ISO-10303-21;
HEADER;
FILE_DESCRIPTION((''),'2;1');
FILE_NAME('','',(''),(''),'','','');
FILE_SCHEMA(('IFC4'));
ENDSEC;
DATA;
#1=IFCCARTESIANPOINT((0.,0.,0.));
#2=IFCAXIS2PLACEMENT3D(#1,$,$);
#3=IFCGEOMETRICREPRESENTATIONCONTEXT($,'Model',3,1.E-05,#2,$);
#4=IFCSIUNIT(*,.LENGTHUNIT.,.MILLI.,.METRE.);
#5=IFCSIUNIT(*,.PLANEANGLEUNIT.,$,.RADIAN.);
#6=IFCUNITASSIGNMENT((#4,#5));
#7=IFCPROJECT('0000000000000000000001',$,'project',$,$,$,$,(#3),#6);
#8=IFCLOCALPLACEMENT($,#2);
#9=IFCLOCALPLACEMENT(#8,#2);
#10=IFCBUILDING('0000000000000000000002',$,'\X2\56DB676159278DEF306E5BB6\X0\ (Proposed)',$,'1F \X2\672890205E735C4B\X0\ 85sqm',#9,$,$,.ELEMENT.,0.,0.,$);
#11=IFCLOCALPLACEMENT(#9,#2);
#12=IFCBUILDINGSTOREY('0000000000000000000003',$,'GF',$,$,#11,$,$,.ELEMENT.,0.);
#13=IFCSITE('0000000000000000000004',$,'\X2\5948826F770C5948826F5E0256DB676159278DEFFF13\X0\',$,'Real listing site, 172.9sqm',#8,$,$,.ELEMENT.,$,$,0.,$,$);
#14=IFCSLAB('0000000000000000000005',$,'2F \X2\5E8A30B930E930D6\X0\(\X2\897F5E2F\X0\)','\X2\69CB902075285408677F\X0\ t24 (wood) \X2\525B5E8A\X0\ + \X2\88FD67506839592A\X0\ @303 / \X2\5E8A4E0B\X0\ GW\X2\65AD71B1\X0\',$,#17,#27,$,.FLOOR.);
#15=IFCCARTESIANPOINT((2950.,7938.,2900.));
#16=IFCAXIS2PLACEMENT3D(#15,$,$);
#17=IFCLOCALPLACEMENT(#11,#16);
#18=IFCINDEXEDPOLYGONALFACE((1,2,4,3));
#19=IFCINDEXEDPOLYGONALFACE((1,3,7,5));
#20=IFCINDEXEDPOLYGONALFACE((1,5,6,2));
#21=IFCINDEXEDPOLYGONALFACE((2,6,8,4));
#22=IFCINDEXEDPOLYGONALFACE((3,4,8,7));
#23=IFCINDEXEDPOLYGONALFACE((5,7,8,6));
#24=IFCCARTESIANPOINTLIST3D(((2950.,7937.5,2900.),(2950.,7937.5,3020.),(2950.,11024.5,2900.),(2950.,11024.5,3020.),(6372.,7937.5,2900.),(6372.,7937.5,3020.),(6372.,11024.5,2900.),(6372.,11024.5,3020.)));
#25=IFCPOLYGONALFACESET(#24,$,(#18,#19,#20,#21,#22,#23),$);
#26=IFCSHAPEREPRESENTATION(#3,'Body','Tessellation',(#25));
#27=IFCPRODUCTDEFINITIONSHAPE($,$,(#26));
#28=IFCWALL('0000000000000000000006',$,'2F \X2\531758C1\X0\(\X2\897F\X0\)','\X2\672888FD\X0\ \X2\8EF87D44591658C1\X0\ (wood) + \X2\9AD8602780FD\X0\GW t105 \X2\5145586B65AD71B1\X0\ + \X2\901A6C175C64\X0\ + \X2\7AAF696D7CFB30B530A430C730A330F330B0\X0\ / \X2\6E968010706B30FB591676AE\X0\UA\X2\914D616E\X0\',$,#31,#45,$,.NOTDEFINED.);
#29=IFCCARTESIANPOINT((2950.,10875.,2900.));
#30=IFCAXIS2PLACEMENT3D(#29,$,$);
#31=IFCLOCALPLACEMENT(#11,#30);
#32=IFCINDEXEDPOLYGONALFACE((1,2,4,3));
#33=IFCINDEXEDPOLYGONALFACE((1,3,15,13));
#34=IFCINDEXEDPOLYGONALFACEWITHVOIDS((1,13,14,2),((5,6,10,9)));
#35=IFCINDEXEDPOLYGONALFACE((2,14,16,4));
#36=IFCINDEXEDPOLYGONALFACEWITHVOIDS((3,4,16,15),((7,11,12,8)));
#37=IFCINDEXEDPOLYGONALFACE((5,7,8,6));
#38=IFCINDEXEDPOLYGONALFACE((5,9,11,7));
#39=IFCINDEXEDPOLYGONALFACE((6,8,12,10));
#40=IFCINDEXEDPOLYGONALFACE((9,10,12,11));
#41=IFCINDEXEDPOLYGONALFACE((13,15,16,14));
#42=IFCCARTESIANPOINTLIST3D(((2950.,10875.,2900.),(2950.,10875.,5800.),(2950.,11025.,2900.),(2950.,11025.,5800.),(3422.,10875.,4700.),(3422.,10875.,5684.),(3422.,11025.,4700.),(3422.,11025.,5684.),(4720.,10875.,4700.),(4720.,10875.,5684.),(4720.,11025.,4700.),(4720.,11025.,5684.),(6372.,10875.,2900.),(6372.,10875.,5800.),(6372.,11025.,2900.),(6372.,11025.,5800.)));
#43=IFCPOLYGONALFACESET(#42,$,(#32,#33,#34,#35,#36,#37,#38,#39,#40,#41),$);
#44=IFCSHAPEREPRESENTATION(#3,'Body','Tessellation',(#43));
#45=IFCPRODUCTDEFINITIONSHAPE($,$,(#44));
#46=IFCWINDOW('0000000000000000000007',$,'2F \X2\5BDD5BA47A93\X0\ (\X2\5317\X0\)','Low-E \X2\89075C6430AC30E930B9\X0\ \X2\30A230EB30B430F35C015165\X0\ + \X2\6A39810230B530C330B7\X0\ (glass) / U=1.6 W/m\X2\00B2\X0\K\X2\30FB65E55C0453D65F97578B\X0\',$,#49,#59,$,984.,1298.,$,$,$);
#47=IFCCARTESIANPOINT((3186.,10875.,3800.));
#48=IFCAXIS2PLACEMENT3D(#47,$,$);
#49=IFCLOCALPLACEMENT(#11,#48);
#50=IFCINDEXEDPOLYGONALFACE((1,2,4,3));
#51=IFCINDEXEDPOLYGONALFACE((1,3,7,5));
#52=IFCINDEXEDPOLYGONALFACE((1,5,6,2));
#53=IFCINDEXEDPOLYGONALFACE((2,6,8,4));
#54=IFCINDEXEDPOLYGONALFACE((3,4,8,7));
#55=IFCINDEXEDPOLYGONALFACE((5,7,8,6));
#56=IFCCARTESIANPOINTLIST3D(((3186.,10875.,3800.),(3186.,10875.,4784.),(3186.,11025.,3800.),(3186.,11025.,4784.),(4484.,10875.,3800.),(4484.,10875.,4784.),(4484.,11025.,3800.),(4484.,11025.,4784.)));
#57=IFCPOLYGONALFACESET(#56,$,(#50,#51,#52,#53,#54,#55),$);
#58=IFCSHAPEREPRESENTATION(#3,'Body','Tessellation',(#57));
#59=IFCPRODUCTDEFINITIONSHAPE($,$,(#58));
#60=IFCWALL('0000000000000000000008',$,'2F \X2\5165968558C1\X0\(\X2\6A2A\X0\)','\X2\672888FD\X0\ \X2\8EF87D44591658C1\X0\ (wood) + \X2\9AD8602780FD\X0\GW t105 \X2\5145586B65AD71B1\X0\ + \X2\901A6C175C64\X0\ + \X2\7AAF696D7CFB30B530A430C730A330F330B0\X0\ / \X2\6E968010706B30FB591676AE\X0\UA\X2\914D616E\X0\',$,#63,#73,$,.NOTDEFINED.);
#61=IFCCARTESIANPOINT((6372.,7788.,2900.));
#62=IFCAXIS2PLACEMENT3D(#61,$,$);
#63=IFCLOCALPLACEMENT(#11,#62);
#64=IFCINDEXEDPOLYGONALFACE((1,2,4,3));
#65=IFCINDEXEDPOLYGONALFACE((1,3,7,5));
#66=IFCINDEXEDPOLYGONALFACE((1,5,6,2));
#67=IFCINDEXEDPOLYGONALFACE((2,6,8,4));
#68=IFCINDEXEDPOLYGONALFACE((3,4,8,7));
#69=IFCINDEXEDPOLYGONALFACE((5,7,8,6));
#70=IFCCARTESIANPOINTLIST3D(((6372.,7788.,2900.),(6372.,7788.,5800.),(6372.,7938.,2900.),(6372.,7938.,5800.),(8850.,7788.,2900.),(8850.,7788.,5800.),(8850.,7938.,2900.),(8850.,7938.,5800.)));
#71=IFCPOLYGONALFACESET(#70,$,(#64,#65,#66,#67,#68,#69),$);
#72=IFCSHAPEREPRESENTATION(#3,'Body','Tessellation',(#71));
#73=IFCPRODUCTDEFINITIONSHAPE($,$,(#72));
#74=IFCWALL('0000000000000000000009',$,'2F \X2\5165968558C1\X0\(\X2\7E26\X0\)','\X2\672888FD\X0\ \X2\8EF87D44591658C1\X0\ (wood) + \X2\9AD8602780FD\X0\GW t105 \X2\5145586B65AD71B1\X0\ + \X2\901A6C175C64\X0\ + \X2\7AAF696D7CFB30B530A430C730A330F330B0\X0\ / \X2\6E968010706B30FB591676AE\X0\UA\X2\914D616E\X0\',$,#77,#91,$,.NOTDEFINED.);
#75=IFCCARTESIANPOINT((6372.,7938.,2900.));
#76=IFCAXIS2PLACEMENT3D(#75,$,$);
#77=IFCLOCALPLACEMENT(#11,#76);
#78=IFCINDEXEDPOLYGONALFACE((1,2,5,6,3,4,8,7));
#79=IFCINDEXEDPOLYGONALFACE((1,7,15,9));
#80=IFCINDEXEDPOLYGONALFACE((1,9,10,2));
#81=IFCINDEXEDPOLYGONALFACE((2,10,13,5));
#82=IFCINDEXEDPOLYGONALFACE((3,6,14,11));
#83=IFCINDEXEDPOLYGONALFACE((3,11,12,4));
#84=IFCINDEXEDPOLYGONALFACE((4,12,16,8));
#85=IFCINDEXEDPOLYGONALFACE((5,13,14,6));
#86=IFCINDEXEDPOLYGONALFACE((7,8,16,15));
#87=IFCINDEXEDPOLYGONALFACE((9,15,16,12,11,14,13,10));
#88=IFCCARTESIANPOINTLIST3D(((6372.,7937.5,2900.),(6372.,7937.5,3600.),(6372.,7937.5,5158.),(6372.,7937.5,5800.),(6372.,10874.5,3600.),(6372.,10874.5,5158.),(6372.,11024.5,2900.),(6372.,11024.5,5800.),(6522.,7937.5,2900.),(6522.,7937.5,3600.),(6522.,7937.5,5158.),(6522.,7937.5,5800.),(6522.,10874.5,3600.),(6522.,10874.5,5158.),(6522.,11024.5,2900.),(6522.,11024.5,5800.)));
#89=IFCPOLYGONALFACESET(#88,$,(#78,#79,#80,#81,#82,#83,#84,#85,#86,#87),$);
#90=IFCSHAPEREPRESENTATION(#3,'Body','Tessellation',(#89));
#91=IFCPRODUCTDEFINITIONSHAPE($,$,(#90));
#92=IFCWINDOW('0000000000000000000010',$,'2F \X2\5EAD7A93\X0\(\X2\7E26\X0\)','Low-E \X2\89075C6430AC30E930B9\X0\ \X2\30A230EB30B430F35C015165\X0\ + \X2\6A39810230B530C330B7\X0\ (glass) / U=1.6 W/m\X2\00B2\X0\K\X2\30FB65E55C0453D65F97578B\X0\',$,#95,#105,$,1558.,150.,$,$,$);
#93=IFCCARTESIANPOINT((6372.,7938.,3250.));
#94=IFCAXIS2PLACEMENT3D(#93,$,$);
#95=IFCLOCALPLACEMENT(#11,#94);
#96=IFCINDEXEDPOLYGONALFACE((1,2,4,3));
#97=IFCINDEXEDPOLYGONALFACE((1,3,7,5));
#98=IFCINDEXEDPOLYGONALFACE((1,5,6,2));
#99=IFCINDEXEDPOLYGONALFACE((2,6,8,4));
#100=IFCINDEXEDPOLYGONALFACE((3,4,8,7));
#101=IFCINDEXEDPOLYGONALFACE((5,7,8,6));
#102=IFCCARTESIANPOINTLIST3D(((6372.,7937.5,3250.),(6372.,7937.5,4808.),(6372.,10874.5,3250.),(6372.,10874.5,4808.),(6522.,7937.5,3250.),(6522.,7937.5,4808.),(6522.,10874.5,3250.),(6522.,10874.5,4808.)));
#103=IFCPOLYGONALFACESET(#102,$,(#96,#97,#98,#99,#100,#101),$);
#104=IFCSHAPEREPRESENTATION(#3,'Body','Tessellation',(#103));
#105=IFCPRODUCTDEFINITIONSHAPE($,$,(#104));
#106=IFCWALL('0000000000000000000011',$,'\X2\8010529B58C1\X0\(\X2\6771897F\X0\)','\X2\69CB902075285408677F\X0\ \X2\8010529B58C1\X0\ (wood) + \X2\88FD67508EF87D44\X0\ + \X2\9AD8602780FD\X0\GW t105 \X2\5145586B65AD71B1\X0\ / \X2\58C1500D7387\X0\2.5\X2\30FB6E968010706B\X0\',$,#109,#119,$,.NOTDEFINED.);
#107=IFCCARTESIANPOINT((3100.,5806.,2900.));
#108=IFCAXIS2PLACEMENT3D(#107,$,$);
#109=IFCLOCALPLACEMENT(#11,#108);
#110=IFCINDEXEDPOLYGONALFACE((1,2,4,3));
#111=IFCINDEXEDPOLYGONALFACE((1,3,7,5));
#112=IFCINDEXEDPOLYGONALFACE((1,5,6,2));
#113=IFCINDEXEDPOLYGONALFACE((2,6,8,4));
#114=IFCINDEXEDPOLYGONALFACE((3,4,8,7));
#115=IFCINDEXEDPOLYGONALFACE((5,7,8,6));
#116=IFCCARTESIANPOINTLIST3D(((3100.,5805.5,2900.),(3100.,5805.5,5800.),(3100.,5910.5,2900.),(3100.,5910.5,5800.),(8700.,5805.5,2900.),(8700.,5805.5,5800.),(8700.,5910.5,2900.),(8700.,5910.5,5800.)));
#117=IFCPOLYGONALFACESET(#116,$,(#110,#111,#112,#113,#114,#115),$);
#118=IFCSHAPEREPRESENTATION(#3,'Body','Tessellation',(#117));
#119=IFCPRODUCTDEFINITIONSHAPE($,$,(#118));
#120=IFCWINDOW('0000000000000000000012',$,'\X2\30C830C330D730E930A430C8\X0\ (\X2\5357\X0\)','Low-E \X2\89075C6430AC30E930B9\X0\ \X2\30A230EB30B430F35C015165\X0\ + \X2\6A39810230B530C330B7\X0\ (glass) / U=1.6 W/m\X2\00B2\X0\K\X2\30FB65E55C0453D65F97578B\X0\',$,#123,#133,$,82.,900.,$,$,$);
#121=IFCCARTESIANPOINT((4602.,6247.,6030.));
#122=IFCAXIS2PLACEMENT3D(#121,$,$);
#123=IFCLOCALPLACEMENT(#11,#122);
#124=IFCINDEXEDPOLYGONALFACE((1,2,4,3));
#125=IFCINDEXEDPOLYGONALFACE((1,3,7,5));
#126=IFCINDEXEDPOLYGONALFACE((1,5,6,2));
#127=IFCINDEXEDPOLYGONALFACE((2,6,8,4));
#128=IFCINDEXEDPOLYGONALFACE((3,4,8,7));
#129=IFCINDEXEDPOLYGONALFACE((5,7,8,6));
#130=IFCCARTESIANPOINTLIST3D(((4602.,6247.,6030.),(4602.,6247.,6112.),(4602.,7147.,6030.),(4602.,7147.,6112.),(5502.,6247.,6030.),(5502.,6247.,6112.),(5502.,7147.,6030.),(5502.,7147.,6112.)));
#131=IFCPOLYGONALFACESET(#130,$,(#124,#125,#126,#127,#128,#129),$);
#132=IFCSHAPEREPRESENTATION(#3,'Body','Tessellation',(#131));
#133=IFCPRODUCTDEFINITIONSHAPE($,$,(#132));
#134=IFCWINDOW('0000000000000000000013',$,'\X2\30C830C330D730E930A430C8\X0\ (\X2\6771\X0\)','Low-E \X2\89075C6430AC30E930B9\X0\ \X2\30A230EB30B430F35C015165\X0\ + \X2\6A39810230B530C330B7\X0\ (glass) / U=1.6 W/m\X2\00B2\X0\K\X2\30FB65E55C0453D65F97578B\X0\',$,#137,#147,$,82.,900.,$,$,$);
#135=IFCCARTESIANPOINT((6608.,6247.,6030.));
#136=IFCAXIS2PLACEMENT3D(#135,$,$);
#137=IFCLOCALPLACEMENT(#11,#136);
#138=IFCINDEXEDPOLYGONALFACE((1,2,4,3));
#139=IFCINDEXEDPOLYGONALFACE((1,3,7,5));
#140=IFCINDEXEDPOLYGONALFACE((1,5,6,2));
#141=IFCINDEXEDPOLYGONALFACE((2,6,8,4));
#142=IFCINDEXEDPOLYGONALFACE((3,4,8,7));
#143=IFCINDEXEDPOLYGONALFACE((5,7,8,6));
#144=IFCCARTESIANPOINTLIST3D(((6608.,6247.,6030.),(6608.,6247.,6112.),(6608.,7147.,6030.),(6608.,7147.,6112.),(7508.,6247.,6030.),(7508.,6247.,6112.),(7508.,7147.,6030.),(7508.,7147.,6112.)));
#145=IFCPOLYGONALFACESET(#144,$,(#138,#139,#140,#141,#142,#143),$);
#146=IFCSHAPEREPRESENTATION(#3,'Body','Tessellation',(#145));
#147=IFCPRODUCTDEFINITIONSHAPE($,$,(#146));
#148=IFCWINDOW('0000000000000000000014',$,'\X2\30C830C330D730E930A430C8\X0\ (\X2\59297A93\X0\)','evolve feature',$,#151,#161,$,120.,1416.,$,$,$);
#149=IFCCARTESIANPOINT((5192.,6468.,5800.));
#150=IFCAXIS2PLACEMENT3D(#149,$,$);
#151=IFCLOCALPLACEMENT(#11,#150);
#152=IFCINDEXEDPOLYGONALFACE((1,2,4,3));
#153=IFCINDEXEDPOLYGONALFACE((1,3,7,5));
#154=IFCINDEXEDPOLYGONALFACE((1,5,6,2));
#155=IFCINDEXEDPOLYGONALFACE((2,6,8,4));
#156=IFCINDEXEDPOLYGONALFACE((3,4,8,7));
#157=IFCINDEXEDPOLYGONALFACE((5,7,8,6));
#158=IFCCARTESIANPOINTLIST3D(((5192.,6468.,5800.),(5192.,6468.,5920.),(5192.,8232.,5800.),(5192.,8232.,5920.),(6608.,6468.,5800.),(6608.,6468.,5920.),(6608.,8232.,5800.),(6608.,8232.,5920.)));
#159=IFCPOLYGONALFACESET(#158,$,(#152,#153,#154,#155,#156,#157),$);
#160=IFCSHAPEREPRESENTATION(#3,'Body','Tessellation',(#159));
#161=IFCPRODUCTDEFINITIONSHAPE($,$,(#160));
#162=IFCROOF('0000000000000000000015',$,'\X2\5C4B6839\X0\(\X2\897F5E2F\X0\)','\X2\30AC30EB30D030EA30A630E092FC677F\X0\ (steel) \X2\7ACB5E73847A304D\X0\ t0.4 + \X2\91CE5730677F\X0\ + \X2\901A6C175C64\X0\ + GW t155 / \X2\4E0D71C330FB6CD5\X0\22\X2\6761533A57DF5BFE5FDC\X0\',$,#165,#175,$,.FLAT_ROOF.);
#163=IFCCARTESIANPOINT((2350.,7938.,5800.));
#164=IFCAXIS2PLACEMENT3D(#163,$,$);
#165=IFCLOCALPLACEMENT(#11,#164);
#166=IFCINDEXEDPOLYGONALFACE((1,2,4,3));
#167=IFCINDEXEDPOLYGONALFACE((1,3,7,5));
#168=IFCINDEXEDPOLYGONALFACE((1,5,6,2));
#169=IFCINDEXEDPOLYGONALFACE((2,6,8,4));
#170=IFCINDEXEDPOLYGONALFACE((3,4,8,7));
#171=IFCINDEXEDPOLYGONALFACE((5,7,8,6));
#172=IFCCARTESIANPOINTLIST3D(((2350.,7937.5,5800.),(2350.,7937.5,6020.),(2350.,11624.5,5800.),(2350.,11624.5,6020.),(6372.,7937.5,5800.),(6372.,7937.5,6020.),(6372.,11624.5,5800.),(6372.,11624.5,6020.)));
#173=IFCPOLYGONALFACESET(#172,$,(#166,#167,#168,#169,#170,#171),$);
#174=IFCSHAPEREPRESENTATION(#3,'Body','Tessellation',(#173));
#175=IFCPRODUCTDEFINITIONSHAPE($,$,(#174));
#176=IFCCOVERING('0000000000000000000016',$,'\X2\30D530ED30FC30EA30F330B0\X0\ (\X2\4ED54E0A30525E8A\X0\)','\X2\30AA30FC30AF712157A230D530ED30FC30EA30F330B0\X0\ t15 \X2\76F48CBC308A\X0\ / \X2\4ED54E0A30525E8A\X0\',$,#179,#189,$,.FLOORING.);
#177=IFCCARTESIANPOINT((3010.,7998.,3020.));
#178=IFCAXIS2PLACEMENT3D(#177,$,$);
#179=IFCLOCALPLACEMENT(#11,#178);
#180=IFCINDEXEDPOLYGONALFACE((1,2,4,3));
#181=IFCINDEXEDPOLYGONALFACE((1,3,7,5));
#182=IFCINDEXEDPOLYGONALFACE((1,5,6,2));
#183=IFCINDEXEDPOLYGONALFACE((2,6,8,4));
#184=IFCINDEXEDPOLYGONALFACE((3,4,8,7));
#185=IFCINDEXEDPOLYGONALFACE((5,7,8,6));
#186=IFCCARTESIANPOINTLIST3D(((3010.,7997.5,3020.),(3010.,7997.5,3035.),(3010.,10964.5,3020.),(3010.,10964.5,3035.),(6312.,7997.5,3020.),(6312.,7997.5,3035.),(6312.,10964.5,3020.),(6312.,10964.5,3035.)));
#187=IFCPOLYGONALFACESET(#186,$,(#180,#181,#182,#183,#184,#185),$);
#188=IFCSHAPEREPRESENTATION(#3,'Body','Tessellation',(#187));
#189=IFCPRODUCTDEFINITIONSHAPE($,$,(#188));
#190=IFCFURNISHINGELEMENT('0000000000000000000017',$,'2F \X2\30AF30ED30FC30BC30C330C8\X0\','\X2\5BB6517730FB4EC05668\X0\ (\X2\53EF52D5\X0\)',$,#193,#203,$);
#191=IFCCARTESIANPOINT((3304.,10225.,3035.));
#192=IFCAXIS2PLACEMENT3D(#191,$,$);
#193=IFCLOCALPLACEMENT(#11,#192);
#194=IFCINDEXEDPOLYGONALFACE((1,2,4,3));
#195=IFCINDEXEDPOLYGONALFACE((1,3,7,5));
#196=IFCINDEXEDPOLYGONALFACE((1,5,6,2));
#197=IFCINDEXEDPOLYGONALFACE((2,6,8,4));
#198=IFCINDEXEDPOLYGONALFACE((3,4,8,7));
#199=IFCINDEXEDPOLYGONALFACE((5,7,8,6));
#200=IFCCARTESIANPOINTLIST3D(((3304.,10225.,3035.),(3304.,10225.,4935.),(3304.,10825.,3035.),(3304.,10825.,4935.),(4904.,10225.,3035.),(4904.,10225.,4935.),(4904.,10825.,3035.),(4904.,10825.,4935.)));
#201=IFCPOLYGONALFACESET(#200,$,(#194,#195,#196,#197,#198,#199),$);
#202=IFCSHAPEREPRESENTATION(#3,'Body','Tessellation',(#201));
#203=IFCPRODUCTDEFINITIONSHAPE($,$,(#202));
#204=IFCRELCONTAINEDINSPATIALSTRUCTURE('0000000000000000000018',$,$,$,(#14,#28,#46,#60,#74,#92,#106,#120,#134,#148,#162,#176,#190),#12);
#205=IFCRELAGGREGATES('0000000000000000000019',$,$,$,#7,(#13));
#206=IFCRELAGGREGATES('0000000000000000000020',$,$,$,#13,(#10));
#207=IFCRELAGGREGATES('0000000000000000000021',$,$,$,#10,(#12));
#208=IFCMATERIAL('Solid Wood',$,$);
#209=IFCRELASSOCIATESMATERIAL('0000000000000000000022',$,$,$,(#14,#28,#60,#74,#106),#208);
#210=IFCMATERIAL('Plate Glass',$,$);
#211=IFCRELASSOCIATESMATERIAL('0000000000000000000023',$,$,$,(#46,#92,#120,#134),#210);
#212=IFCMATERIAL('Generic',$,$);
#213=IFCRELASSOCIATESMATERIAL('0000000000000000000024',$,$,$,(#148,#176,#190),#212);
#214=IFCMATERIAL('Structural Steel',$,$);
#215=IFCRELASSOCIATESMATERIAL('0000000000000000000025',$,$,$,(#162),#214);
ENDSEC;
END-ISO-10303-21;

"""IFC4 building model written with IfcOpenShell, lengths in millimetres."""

from ifc_helpers import new_model, si_unit, frame, frame_2d, origin, place, context, project, spatial, rectangle, extrude, material, element, fill, save


model = new_model("IFC4")

# Units and contexts
model_context = context("Model", 3, precision=1e-05, world=origin())
ifc_project = project(units=[si_unit("LENGTHUNIT", "METRE", prefix="MILLI"), si_unit("PLANEANGLEUNIT", "RADIAN")], contexts=[model_context])

# Site, building, storey
site_placement = place(None, origin())
site = spatial("IfcSite", under=ifc_project, at=site_placement, Name="奈良県奈良市四条大路３", ObjectType="Real listing site, 172.9sqm", CompositionType="ELEMENT", RefElevation=0.0)
building_placement = place(site_placement, origin())
building = spatial("IfcBuilding", under=site, at=building_placement, Name="四条大路の家 (Proposed)", ObjectType="1F 木造平屋 85sqm", CompositionType="ELEMENT", ElevationOfRefHeight=0.0, ElevationOfTerrain=0.0)
storey_placement = place(building_placement, origin())
storey = spatial("IfcBuildingStorey", under=building, at=storey_placement, Name="GF", CompositionType="ELEMENT", Elevation=0.0)

# Slab
ifc_material_1 = material(Name="Solid Wood")
slab_placement = place(storey_placement, frame((2950.0, 7938.0, 2900.0)))
element("IfcSlab", 1, at=slab_placement, inside=storey, material=ifc_material_1, Name="2F 床スラブ(西帯)", Description="構造用合板 t24 (wood) 剛床 + 製材根太 @303 / 床下 GW断熱", PredefinedType="FLOOR", context=model_context, shape_type="SweptSolid", body=[
    extrude(rectangle(XDim=3422.0, YDim=3087.0, at=frame_2d((1711.0, 1543.0))), frame((2950.0, 7938.0, 2900.0)), (0.0, 0.0, 1.0), 120.0),
])

# Wall, opening, window
wall_1_placement = place(storey_placement, frame((2950.0, 10875.0, 2900.0)))
wall_1 = element("IfcWall", 2, at=wall_1_placement, inside=storey, material=ifc_material_1, Name="2F 北壁(西)", Description="木製 軸組外壁 (wood) + 高性能GW t105 充填断熱 + 通気層 + 窯業系サイディング / 準耐火・外皮UA配慮", PredefinedType="NOTDEFINED", context=model_context, shape_type="SweptSolid", body=[
    extrude(rectangle(XDim=3422.0, YDim=150.0, at=frame_2d((1711.0, 75.0))), frame((2950.0, 10875.0, 2900.0)), (0.0, 0.0, 1.0), 2900.0),
])
opening_1_placement = place(storey_placement, frame((3186.0, 10875.0, 3800.0)))
opening_1 = element("IfcOpeningElement", 3, at=opening_1_placement, cuts=wall_1, PredefinedType="NOTDEFINED", context=model_context, shape_type="SweptSolid", body=[
    extrude(rectangle(XDim=1298.0, YDim=150.0, at=frame_2d((649.0, 75.0))), frame((3186.0, 10875.0, 3800.0)), (0.0, 0.0, 1.0), 984.0),
])
ifc_material_2 = material(Name="Plate Glass")
window_1_placement = place(storey_placement, frame((3186.0, 10875.0, 3800.0)))
window_1 = element("IfcWindow", 4, at=window_1_placement, inside=storey, material=ifc_material_2, Name="2F 寝室窓 (北)", Description="Low-E 複層ガラス アルゴン封入 + 樹脂サッシ (glass) / U=1.6 W/m²K・日射取得型", OverallHeight=984.0, OverallWidth=1298.0, context=model_context, shape_type="SweptSolid", body=[
    extrude(rectangle(XDim=1298.0, YDim=150.0, at=frame_2d((649.0, 75.0))), frame((3186.0, 10875.0, 3800.0)), (0.0, 0.0, 1.0), 984.0),
])
fill(opening_1, window_1)

# Wall
wall_2_placement = place(storey_placement, frame((6372.0, 7788.0, 2900.0)))
element("IfcWall", 5, at=wall_2_placement, inside=storey, material=ifc_material_1, Name="2F 入隅壁(横)", Description="木製 軸組外壁 (wood) + 高性能GW t105 充填断熱 + 通気層 + 窯業系サイディング / 準耐火・外皮UA配慮", PredefinedType="NOTDEFINED", context=model_context, shape_type="SweptSolid", body=[
    extrude(rectangle(XDim=2478.0, YDim=150.0, at=frame_2d((1239.0, 75.0))), frame((6372.0, 7788.0, 2900.0)), (0.0, 0.0, 1.0), 2900.0),
])

# Wall, opening, window
wall_3_placement = place(storey_placement, frame((6372.0, 7938.0, 2900.0)))
wall_3 = element("IfcWall", 6, at=wall_3_placement, inside=storey, material=ifc_material_1, Name="2F 入隅壁(縦)", Description="木製 軸組外壁 (wood) + 高性能GW t105 充填断熱 + 通気層 + 窯業系サイディング / 準耐火・外皮UA配慮", PredefinedType="NOTDEFINED", context=model_context, shape_type="SweptSolid", body=[
    extrude(rectangle(XDim=150.0, YDim=3087.0, at=frame_2d((75.0, 1543.0))), frame((6372.0, 7938.0, 2900.0)), (0.0, 0.0, 1.0), 2900.0),
])
opening_2_placement = place(storey_placement, frame((6372.0, 7938.0, 3250.0)))
opening_2 = element("IfcOpeningElement", 7, at=opening_2_placement, cuts=wall_3, PredefinedType="NOTDEFINED", context=model_context, shape_type="SweptSolid", body=[
    extrude(rectangle(XDim=150.0, YDim=2937.0, at=frame_2d((75.0, 1468.0))), frame((6372.0, 7938.0, 3250.0)), (0.0, 0.0, 1.0), 1558.0),
])
window_2_placement = place(storey_placement, frame((6372.0, 7938.0, 3250.0)))
window_2 = element("IfcWindow", 8, at=window_2_placement, inside=storey, material=ifc_material_2, Name="2F 庭窓(縦)", Description="Low-E 複層ガラス アルゴン封入 + 樹脂サッシ (glass) / U=1.6 W/m²K・日射取得型", OverallHeight=1558.0, OverallWidth=150.0, context=model_context, shape_type="SweptSolid", body=[
    extrude(rectangle(XDim=150.0, YDim=2937.0, at=frame_2d((75.0, 1468.0))), frame((6372.0, 7938.0, 3250.0)), (0.0, 0.0, 1.0), 1558.0),
])
fill(opening_2, window_2)

# Wall
wall_4_placement = place(storey_placement, frame((3100.0, 5806.0, 2900.0)))
element("IfcWall", 9, at=wall_4_placement, inside=storey, material=ifc_material_1, Name="耐力壁(東西)", Description="構造用合板 耐力壁 (wood) + 製材軸組 + 高性能GW t105 充填断熱 / 壁倍率2.5・準耐火", PredefinedType="NOTDEFINED", context=model_context, shape_type="SweptSolid", body=[
    extrude(rectangle(XDim=5600.0, YDim=105.0, at=frame_2d((2800.0, 52.0))), frame((3100.0, 5806.0, 2900.0)), (0.0, 0.0, 1.0), 2900.0),
])

# Windows
window_3_placement = place(storey_placement, frame((4602.0, 6247.0, 6030.0)))
element("IfcWindow", 10, at=window_3_placement, inside=storey, material=ifc_material_2, Name="トップライト (南)", Description="Low-E 複層ガラス アルゴン封入 + 樹脂サッシ (glass) / U=1.6 W/m²K・日射取得型", OverallHeight=82.0, OverallWidth=900.0, context=model_context, shape_type="SweptSolid", body=[
    extrude(rectangle(XDim=900.0, YDim=900.0, at=frame_2d((450.0, 450.0))), frame((4602.0, 6247.0, 6030.0)), (0.0, 0.0, 1.0), 82.0),
])
window_4_placement = place(storey_placement, frame((6608.0, 6247.0, 6030.0)))
element("IfcWindow", 11, at=window_4_placement, inside=storey, material=ifc_material_2, Name="トップライト (東)", Description="Low-E 複層ガラス アルゴン封入 + 樹脂サッシ (glass) / U=1.6 W/m²K・日射取得型", OverallHeight=82.0, OverallWidth=900.0, context=model_context, shape_type="SweptSolid", body=[
    extrude(rectangle(XDim=900.0, YDim=900.0, at=frame_2d((450.0, 450.0))), frame((6608.0, 6247.0, 6030.0)), (0.0, 0.0, 1.0), 82.0),
])
ifc_material_3 = material(Name="Generic")
window_5_placement = place(storey_placement, frame((5192.0, 6468.0, 5800.0)))
element("IfcWindow", 12, at=window_5_placement, inside=storey, material=ifc_material_3, Name="トップライト (天窓)", Description="evolve feature", OverallHeight=120.0, OverallWidth=1416.0, context=model_context, shape_type="SweptSolid", body=[
    extrude(rectangle(XDim=1416.0, YDim=1764.0, at=frame_2d((708.0, 882.0))), frame((5192.0, 6468.0, 5800.0)), (0.0, 0.0, 1.0), 120.0),
])

# Roof
ifc_material_4 = material(Name="Structural Steel")
for number, where, name in (
    (13, (2350.0, 7938.0, 5800.0), "屋根(西帯)"),
):
    element("IfcRoof", number, at=place(storey_placement, frame(where)), inside=storey, material=ifc_material_4, Name=name, Description="ガルバリウム鋼板 (steel) 立平葺き t0.4 + 野地板 + 通気層 + GW t155 / 不燃・法22条区域対応", PredefinedType="FLAT_ROOF", context=model_context, shape_type="SweptSolid", body=[
        extrude(rectangle(XDim=4022.0, YDim=3687.0, at=frame_2d((2011.0, 1843.0))), frame((2350.0, 7938.0, 5800.0)), (0.0, 0.0, 1.0), 220.0),
    ])

# Covering
covering_placement = place(storey_placement, frame((3010.0, 7998.0, 3020.0)))
element("IfcCovering", 14, at=covering_placement, inside=storey, material=ifc_material_3, Name="フローリング (仕上げ床)", Description="オーク無垢フローリング t15 直貼り / 仕上げ床", PredefinedType="FLOORING", context=model_context, shape_type="SweptSolid", body=[
    extrude(rectangle(XDim=3302.0, YDim=2967.0, at=frame_2d((1651.0, 1483.0))), frame((3010.0, 7998.0, 3020.0)), (0.0, 0.0, 1.0), 15.0),
])

# Furnishing element
furnishing_1_placement = place(storey_placement, frame((3304.0, 10225.0, 3035.0)))
element("IfcFurnishingElement", 15, at=furnishing_1_placement, inside=storey, material=ifc_material_3, Name="2F クローゼット", Description="家具・什器 (可動)", context=model_context, shape_type="SweptSolid", body=[
    extrude(rectangle(XDim=1600.0, YDim=600.0, at=frame_2d((800.0, 300.0))), frame((3304.0, 10225.0, 3035.0)), (0.0, 0.0, 1.0), 1900.0),
])

save(model, "model.ifc")
